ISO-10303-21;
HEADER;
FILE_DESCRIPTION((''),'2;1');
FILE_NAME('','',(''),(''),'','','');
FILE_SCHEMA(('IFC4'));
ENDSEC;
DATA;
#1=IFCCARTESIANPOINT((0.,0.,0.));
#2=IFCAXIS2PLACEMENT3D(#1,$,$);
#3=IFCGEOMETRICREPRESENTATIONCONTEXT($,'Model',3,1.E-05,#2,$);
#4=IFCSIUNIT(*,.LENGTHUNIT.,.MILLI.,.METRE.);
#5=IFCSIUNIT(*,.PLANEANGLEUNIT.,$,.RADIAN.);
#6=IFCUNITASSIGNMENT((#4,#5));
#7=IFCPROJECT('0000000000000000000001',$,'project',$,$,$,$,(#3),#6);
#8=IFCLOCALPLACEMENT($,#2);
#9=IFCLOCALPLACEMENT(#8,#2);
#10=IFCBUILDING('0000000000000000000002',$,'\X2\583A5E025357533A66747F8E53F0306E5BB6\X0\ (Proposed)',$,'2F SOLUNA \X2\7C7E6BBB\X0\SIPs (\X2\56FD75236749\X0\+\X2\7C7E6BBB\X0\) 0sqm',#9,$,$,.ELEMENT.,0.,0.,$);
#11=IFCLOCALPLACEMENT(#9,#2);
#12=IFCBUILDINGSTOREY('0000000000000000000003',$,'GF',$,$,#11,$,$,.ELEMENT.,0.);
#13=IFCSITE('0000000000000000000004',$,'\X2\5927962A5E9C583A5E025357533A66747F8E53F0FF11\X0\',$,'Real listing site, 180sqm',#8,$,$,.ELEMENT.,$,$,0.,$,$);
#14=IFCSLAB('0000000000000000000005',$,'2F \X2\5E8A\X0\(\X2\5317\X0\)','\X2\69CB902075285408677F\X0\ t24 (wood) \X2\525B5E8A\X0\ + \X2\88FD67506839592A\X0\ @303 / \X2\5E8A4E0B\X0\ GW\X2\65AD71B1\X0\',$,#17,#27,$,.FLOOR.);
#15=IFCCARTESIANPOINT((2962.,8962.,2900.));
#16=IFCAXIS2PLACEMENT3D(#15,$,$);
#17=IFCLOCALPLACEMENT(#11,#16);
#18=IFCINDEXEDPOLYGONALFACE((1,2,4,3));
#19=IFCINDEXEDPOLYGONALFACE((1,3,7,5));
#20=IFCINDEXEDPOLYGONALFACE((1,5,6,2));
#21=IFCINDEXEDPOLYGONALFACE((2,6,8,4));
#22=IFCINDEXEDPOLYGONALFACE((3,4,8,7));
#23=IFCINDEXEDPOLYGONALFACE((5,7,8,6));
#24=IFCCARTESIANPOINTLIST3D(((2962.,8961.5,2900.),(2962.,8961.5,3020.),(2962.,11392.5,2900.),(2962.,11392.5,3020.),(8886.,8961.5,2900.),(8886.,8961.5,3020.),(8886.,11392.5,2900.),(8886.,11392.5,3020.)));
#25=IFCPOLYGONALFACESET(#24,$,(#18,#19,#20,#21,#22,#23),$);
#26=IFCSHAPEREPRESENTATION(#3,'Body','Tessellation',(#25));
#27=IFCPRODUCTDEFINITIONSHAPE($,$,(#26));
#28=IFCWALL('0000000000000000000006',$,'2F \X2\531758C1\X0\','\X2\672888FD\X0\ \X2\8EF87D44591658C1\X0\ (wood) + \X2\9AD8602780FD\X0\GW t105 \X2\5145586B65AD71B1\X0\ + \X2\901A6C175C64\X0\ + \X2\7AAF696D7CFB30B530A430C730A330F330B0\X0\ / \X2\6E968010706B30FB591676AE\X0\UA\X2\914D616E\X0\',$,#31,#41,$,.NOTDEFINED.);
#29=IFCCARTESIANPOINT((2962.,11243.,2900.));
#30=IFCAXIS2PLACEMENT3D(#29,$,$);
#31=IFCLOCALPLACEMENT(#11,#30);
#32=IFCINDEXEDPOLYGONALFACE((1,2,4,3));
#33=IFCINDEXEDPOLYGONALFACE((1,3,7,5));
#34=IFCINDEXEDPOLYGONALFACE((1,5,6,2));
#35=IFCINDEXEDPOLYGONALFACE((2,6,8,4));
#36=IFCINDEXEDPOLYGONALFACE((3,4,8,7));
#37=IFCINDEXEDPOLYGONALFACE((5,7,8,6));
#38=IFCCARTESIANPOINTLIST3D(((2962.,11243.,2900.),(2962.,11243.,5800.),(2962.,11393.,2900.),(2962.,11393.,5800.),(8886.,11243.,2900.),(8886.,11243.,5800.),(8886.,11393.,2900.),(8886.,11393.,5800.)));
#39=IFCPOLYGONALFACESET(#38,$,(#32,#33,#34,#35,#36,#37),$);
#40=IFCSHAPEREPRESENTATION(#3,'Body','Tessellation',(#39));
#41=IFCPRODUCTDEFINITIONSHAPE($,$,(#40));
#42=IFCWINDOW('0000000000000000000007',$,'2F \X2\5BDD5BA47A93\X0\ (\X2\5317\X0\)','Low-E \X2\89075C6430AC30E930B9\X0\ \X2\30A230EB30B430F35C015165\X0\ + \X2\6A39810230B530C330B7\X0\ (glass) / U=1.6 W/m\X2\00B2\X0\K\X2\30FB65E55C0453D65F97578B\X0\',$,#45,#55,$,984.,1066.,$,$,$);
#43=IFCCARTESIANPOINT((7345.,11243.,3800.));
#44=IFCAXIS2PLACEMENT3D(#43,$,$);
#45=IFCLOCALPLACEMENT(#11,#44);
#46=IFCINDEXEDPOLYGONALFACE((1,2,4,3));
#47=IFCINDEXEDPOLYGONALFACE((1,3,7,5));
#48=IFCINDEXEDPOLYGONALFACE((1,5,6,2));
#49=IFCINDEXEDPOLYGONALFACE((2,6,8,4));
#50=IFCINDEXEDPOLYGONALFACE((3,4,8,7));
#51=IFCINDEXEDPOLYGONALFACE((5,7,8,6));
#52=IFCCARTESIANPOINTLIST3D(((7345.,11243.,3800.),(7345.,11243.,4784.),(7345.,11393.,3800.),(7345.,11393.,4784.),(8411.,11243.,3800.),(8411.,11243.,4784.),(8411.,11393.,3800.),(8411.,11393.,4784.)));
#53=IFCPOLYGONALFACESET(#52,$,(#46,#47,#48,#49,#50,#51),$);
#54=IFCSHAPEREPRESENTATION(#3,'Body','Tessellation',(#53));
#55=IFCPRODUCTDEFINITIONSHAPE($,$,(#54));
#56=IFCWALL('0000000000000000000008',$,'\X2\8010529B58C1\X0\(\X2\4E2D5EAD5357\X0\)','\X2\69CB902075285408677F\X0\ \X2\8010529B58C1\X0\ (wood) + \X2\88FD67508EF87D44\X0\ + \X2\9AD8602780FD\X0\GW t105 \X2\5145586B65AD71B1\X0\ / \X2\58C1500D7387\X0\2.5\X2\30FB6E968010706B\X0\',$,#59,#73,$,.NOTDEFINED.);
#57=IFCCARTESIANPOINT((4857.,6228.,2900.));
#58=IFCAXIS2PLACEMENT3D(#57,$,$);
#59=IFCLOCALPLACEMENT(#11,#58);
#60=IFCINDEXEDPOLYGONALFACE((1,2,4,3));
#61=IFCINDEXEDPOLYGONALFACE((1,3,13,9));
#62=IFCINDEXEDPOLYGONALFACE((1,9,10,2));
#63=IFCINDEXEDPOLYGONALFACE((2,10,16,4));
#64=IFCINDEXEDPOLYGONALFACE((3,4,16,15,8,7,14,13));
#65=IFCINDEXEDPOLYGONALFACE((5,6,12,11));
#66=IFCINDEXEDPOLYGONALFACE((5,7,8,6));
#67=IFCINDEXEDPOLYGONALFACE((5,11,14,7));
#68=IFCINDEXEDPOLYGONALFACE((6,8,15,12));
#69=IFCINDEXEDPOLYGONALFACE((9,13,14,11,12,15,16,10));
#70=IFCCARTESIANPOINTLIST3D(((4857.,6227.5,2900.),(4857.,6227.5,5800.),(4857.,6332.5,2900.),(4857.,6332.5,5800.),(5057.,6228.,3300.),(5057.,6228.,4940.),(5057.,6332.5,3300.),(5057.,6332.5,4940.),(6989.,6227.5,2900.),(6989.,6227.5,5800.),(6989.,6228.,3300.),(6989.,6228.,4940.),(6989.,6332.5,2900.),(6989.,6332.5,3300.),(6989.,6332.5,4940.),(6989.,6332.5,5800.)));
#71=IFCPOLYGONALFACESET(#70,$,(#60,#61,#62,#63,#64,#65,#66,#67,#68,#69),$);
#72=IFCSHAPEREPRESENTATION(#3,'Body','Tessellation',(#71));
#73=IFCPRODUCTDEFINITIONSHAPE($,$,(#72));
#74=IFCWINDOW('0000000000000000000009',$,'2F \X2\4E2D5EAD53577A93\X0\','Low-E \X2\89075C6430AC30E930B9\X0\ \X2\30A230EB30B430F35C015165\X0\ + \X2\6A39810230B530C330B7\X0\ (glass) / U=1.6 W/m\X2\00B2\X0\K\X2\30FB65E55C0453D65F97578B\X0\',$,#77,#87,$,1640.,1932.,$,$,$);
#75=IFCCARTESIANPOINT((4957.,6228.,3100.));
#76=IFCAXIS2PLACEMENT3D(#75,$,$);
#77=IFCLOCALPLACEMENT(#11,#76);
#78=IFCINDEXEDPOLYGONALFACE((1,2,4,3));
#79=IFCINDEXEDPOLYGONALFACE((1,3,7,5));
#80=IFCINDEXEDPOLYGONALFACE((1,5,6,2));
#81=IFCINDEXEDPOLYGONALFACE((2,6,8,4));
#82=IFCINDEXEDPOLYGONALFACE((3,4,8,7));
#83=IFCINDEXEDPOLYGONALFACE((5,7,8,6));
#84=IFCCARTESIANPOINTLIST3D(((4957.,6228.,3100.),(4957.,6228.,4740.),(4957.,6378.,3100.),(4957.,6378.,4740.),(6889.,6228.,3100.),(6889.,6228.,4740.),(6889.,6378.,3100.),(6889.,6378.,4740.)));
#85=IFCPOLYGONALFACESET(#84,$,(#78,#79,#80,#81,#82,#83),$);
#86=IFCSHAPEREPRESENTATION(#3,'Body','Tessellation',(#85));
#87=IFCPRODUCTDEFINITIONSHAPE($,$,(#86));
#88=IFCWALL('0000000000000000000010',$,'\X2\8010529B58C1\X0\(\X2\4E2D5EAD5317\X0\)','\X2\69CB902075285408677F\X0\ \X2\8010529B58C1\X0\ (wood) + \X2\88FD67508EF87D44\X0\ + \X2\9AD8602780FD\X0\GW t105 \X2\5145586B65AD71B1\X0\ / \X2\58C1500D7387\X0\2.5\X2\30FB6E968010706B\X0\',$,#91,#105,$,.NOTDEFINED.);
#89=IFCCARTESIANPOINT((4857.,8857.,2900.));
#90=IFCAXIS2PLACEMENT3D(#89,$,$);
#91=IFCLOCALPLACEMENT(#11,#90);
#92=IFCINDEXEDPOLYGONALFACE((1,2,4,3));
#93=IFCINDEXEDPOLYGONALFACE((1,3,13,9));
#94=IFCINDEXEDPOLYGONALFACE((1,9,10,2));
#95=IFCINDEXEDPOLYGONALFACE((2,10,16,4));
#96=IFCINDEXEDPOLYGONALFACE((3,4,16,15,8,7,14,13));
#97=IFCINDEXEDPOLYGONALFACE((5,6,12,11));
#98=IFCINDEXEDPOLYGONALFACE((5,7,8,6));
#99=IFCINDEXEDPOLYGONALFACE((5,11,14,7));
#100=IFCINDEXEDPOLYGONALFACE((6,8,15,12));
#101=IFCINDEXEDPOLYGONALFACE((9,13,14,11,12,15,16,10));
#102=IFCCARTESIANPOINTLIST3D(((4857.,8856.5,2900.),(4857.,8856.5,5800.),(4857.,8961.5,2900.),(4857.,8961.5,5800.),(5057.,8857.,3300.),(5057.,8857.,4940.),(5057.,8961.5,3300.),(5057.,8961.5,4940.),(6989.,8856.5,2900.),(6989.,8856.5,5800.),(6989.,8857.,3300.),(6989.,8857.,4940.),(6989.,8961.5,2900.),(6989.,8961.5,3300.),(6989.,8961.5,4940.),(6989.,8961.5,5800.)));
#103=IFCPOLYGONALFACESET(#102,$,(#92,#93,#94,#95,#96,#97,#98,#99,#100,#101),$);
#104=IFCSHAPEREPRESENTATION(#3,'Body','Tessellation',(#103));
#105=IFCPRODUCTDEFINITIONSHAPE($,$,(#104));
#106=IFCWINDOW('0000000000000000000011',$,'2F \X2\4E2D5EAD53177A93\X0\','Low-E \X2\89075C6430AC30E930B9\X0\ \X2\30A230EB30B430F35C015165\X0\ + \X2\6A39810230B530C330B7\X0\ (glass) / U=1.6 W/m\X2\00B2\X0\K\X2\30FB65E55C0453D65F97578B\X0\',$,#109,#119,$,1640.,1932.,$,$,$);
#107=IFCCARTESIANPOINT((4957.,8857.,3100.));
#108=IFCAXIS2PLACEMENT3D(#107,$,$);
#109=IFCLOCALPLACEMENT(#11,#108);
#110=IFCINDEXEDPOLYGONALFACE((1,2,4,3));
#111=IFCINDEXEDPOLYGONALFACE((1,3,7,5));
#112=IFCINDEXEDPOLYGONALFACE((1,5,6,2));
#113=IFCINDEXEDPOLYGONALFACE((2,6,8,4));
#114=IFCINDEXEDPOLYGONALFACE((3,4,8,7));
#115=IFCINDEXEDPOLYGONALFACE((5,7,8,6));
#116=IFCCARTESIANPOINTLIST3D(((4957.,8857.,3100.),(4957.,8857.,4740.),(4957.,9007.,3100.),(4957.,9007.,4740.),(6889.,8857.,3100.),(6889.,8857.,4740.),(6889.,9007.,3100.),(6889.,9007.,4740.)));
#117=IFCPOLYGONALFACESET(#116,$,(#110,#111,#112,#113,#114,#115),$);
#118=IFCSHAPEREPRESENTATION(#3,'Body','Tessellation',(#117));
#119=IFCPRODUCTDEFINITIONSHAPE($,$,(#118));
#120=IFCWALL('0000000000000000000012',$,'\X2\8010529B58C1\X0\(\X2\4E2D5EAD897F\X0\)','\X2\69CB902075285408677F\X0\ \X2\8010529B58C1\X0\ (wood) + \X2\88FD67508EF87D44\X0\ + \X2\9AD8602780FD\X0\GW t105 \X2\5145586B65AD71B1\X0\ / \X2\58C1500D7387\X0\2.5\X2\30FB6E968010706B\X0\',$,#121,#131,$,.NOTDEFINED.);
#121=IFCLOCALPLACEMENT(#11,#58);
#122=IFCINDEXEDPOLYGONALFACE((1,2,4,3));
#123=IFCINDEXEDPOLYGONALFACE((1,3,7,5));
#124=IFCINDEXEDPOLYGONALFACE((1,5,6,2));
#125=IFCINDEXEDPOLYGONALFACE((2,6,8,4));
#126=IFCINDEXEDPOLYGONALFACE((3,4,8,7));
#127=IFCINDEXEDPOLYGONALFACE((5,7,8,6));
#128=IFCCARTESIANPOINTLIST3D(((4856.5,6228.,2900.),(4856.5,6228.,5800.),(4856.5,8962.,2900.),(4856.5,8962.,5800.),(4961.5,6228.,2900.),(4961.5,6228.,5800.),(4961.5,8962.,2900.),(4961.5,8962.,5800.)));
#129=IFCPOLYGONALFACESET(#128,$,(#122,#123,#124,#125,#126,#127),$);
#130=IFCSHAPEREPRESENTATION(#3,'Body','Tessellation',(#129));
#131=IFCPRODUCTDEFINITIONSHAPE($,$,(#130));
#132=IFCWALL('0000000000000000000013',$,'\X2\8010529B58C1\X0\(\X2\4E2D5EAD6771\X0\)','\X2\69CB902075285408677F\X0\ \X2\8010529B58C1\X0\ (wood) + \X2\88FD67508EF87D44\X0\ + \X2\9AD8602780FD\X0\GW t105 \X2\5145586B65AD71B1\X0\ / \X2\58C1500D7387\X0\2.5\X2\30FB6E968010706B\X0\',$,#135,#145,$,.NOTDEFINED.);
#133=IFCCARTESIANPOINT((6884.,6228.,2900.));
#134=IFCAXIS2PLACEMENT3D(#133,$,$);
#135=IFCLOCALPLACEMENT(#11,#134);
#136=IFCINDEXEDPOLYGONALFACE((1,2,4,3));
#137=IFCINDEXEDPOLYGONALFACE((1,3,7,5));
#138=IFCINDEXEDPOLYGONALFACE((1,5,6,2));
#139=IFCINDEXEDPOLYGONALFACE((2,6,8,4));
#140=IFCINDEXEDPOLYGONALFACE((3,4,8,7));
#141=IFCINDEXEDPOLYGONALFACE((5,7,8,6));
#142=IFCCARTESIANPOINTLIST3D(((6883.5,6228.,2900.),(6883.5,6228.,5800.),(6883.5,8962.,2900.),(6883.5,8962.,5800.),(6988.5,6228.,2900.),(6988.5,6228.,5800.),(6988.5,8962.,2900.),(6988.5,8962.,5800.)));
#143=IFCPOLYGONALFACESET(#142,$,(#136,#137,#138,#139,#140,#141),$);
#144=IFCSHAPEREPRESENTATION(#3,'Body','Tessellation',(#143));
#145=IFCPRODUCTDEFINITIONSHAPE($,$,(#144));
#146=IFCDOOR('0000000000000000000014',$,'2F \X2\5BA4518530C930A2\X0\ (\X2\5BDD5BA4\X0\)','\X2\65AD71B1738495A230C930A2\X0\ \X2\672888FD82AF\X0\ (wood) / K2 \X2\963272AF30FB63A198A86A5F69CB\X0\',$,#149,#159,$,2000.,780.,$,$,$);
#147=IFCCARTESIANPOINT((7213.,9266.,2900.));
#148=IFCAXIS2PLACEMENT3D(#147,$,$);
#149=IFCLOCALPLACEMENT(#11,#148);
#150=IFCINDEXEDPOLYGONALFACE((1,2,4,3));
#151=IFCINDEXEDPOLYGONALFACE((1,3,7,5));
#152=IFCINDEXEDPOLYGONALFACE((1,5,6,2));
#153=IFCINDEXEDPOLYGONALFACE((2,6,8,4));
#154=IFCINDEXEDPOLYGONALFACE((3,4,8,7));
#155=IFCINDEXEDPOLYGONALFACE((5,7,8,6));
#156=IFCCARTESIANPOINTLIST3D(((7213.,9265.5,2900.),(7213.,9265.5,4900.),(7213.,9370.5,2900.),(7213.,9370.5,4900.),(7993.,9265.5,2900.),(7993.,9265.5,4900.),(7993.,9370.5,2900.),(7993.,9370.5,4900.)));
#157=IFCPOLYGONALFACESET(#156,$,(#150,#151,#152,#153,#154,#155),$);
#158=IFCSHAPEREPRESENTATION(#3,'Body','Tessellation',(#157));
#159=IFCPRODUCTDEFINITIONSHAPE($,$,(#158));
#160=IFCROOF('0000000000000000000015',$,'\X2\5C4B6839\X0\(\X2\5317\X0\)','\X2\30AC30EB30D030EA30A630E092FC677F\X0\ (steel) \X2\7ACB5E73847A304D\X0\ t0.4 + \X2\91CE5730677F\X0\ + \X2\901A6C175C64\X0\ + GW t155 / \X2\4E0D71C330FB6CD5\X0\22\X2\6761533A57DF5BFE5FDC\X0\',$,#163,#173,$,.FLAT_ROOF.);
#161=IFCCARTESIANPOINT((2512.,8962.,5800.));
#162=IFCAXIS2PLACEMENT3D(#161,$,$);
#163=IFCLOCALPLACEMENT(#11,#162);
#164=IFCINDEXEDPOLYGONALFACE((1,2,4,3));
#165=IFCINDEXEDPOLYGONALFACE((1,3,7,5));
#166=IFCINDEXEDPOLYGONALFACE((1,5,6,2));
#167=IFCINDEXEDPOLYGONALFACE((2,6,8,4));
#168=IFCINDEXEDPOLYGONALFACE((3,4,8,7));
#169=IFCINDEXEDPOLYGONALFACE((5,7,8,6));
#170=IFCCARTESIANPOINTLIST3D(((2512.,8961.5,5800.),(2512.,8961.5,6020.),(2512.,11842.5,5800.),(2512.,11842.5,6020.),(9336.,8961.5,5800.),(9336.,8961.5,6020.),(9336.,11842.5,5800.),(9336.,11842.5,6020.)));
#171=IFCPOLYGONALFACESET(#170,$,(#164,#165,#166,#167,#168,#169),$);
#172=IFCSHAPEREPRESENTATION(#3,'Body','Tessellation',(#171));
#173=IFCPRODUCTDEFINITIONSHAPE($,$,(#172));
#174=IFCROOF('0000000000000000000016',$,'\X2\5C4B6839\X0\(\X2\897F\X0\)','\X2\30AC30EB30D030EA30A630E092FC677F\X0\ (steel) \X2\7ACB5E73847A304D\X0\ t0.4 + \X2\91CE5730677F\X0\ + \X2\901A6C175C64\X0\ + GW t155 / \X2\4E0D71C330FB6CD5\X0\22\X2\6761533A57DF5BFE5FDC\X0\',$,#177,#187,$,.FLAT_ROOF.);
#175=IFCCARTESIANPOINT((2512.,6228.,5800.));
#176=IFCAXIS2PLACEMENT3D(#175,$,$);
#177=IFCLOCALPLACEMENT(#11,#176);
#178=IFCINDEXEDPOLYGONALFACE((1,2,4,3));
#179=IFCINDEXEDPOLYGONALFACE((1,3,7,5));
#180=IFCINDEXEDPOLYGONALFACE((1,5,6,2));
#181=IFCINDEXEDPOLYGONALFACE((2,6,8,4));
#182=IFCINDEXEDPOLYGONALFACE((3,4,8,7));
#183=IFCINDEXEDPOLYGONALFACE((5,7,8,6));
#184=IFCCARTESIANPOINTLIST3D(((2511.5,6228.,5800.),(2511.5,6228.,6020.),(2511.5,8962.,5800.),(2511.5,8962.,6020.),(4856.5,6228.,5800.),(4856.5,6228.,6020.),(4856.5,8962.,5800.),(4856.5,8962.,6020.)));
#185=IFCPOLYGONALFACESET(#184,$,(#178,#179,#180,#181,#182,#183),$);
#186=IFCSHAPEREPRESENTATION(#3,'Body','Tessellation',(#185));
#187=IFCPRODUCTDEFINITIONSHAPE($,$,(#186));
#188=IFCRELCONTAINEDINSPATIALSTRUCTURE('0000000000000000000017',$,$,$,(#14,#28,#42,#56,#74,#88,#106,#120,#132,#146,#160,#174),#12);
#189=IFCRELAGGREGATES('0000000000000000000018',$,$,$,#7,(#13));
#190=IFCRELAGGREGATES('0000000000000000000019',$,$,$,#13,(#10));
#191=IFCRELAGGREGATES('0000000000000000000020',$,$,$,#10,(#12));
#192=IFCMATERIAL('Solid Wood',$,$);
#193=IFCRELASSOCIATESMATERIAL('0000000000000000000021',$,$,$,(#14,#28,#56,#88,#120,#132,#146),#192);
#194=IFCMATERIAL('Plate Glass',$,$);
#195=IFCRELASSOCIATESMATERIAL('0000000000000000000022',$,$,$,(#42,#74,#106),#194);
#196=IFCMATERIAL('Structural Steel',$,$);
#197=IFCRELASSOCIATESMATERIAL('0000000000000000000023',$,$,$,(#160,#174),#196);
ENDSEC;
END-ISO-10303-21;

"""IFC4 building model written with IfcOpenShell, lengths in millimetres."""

from ifc_helpers import new_model, si_unit, frame, frame_2d, origin, place, context, project, spatial, rectangle, extrude, material, element, fill, save


model = new_model("IFC4")

# Units and contexts
model_context = context("Model", 3, precision=1e-05, world=origin())
ifc_project = project(units=[si_unit("LENGTHUNIT", "METRE", prefix="MILLI"), si_unit("PLANEANGLEUNIT", "RADIAN")], contexts=[model_context])

# Site, building, storey
site_placement = place(None, origin())
site = spatial("IfcSite", under=ifc_project, at=site_placement, Name="大阪府堺市南区晴美台１", ObjectType="Real listing site, 180sqm", CompositionType="ELEMENT", RefElevation=0.0)
building_placement = place(site_placement, origin())
building = spatial("IfcBuilding", under=site, at=building_placement, Name="堺市南区晴美台の家 (Proposed)", ObjectType="2F SOLUNA 籾殻SIPs (国産杉+籾殻) 0sqm", CompositionType="ELEMENT", ElevationOfRefHeight=0.0, ElevationOfTerrain=0.0)
storey_placement = place(building_placement, origin())
storey = spatial("IfcBuildingStorey", under=building, at=storey_placement, Name="GF", CompositionType="ELEMENT", Elevation=0.0)

# Slab
ifc_material_1 = material(Name="Solid Wood")
slab_placement = place(storey_placement, frame((2962.0, 8962.0, 2900.0)))
element("IfcSlab", 1, at=slab_placement, inside=storey, material=ifc_material_1, Name="2F 床(北)", Description="構造用合板 t24 (wood) 剛床 + 製材根太 @303 / 床下 GW断熱", PredefinedType="FLOOR", context=model_context, shape_type="SweptSolid", body=[
    extrude(rectangle(XDim=5924.0, YDim=2431.0, at=frame_2d((2962.0, 1215.0))), frame((2962.0, 8962.0, 2900.0)), (0.0, 0.0, 1.0), 120.0),
])

# Walls, openings, windows
wall_1_placement = place(storey_placement, frame((2962.0, 11243.0, 2900.0)))
wall_1 = element("IfcWall", 2, at=wall_1_placement, inside=storey, material=ifc_material_1, Name="2F 北壁", Description="木製 軸組外壁 (wood) + 高性能GW t105 充填断熱 + 通気層 + 窯業系サイディング / 準耐火・外皮UA配慮", PredefinedType="NOTDEFINED", context=model_context, shape_type="SweptSolid", body=[
    extrude(rectangle(XDim=5924.0, YDim=150.0, at=frame_2d((2962.0, 75.0))), frame((2962.0, 11243.0, 2900.0)), (0.0, 0.0, 1.0), 2900.0),
])
opening_1_placement = place(storey_placement, frame((7345.0, 11243.0, 3800.0)))
opening_1 = element("IfcOpeningElement", 3, at=opening_1_placement, cuts=wall_1, PredefinedType="NOTDEFINED", context=model_context, shape_type="SweptSolid", body=[
    extrude(rectangle(XDim=1066.0, YDim=150.0, at=frame_2d((533.0, 75.0))), frame((7345.0, 11243.0, 3800.0)), (0.0, 0.0, 1.0), 984.0),
])
ifc_material_2 = material(Name="Plate Glass")
window_1_placement = place(storey_placement, frame((7345.0, 11243.0, 3800.0)))
window_1 = element("IfcWindow", 4, at=window_1_placement, inside=storey, material=ifc_material_2, Name="2F 寝室窓 (北)", Description="Low-E 複層ガラス アルゴン封入 + 樹脂サッシ (glass) / U=1.6 W/m²K・日射取得型", OverallHeight=984.0, OverallWidth=1066.0, context=model_context, shape_type="SweptSolid", body=[
    extrude(rectangle(XDim=1066.0, YDim=150.0, at=frame_2d((533.0, 75.0))), frame((7345.0, 11243.0, 3800.0)), (0.0, 0.0, 1.0), 984.0),
])
fill(opening_1, window_1)
wall_2_placement = place(storey_placement, frame((4857.0, 6228.0, 2900.0)))
wall_2 = element("IfcWall", 5, at=wall_2_placement, inside=storey, material=ifc_material_1, Name="耐力壁(中庭南)", Description="構造用合板 耐力壁 (wood) + 製材軸組 + 高性能GW t105 充填断熱 / 壁倍率2.5・準耐火", PredefinedType="NOTDEFINED", context=model_context, shape_type="SweptSolid", body=[
    extrude(rectangle(XDim=2132.0, YDim=105.0, at=frame_2d((1066.0, 52.0))), frame((4857.0, 6228.0, 2900.0)), (0.0, 0.0, 1.0), 2900.0),
])
opening_2_placement = place(storey_placement, frame((4957.0, 6228.0, 3100.0)))
opening_2 = element("IfcOpeningElement", 6, at=opening_2_placement, cuts=wall_2, PredefinedType="NOTDEFINED", context=model_context, shape_type="SweptSolid", body=[
    extrude(rectangle(XDim=1932.0, YDim=150.0, at=frame_2d((966.0, 75.0))), frame((4957.0, 6228.0, 3100.0)), (0.0, 0.0, 1.0), 1640.0),
])
window_2_placement = place(storey_placement, frame((4957.0, 6228.0, 3100.0)))
window_2 = element("IfcWindow", 7, at=window_2_placement, inside=storey, material=ifc_material_2, Name="2F 中庭南窓", Description="Low-E 複層ガラス アルゴン封入 + 樹脂サッシ (glass) / U=1.6 W/m²K・日射取得型", OverallHeight=1640.0, OverallWidth=1932.0, context=model_context, shape_type="SweptSolid", body=[
    extrude(rectangle(XDim=1932.0, YDim=150.0, at=frame_2d((966.0, 75.0))), frame((4957.0, 6228.0, 3100.0)), (0.0, 0.0, 1.0), 1640.0),
])
fill(opening_2, window_2)
wall_3_placement = place(storey_placement, frame((4857.0, 8857.0, 2900.0)))
wall_3 = element("IfcWall", 8, at=wall_3_placement, inside=storey, material=ifc_material_1, Name="耐力壁(中庭北)", Description="構造用合板 耐力壁 (wood) + 製材軸組 + 高性能GW t105 充填断熱 / 壁倍率2.5・準耐火", PredefinedType="NOTDEFINED", context=model_context, shape_type="SweptSolid", body=[
    extrude(rectangle(XDim=2132.0, YDim=105.0, at=frame_2d((1066.0, 52.0))), frame((4857.0, 8857.0, 2900.0)), (0.0, 0.0, 1.0), 2900.0),
])
opening_3_placement = place(storey_placement, frame((4957.0, 8857.0, 3100.0)))
opening_3 = element("IfcOpeningElement", 9, at=opening_3_placement, cuts=wall_3, PredefinedType="NOTDEFINED", context=model_context, shape_type="SweptSolid", body=[
    extrude(rectangle(XDim=1932.0, YDim=150.0, at=frame_2d((966.0, 75.0))), frame((4957.0, 8857.0, 3100.0)), (0.0, 0.0, 1.0), 1640.0),
])
window_3_placement = place(storey_placement, frame((4957.0, 8857.0, 3100.0)))
window_3 = element("IfcWindow", 10, at=window_3_placement, inside=storey, material=ifc_material_2, Name="2F 中庭北窓", Description="Low-E 複層ガラス アルゴン封入 + 樹脂サッシ (glass) / U=1.6 W/m²K・日射取得型", OverallHeight=1640.0, OverallWidth=1932.0, context=model_context, shape_type="SweptSolid", body=[
    extrude(rectangle(XDim=1932.0, YDim=150.0, at=frame_2d((966.0, 75.0))), frame((4957.0, 8857.0, 3100.0)), (0.0, 0.0, 1.0), 1640.0),
])
fill(opening_3, window_3)

# Walls
wall_4_placement = place(storey_placement, frame((4857.0, 6228.0, 2900.0)))
element("IfcWall", 11, at=wall_4_placement, inside=storey, material=ifc_material_1, Name="耐力壁(中庭西)", Description="構造用合板 耐力壁 (wood) + 製材軸組 + 高性能GW t105 充填断熱 / 壁倍率2.5・準耐火", PredefinedType="NOTDEFINED", context=model_context, shape_type="SweptSolid", body=[
    extrude(rectangle(XDim=105.0, YDim=2734.0, at=frame_2d((52.0, 1367.0))), frame((4857.0, 6228.0, 2900.0)), (0.0, 0.0, 1.0), 2900.0),
])
wall_5_placement = place(storey_placement, frame((6884.0, 6228.0, 2900.0)))
element("IfcWall", 12, at=wall_5_placement, inside=storey, material=ifc_material_1, Name="耐力壁(中庭東)", Description="構造用合板 耐力壁 (wood) + 製材軸組 + 高性能GW t105 充填断熱 / 壁倍率2.5・準耐火", PredefinedType="NOTDEFINED", context=model_context, shape_type="SweptSolid", body=[
    extrude(rectangle(XDim=105.0, YDim=2734.0, at=frame_2d((52.0, 1367.0))), frame((6884.0, 6228.0, 2900.0)), (0.0, 0.0, 1.0), 2900.0),
])

# Door
door_placement = place(storey_placement, frame((7213.0, 9266.0, 2900.0)))
element("IfcDoor", 13, at=door_placement, inside=storey, material=ifc_material_1, Name="2F 室内ドア (寝室)", Description="断熱玄関ドア 木製芯 (wood) / K2 防犯・採風機構", OverallHeight=2000.0, OverallWidth=780.0, context=model_context, shape_type="SweptSolid", body=[
    extrude(rectangle(XDim=780.0, YDim=105.0, at=frame_2d((390.0, 52.0))), frame((7213.0, 9266.0, 2900.0)), (0.0, 0.0, 1.0), 2000.0),
])

# Roofs
ifc_material_3 = material(Name="Structural Steel")
for number, where, name in (
    (14, (2512.0, 8962.0, 5800.0), "屋根(北)"),
):
    element("IfcRoof", number, at=place(storey_placement, frame(where)), inside=storey, material=ifc_material_3, Name=name, Description="ガルバリウム鋼板 (steel) 立平葺き t0.4 + 野地板 + 通気層 + GW t155 / 不燃・法22条区域対応", PredefinedType="FLAT_ROOF", context=model_context, shape_type="SweptSolid", body=[
        extrude(rectangle(XDim=6824.0, YDim=2881.0, at=frame_2d((3412.0, 1440.0))), frame((2512.0, 8962.0, 5800.0)), (0.0, 0.0, 1.0), 220.0),
    ])
roof_1_placement = place(storey_placement, frame((2512.0, 6228.0, 5800.0)))
element("IfcRoof", 15, at=roof_1_placement, inside=storey, material=ifc_material_3, Name="屋根(西)", Description="ガルバリウム鋼板 (steel) 立平葺き t0.4 + 野地板 + 通気層 + GW t155 / 不燃・法22条区域対応", PredefinedType="FLAT_ROOF", context=model_context, shape_type="SweptSolid", body=[
    extrude(rectangle(XDim=2345.0, YDim=2734.0, at=frame_2d((1172.0, 1367.0))), frame((2512.0, 6228.0, 5800.0)), (0.0, 0.0, 1.0), 220.0),
])

save(model, "model.ifc")
